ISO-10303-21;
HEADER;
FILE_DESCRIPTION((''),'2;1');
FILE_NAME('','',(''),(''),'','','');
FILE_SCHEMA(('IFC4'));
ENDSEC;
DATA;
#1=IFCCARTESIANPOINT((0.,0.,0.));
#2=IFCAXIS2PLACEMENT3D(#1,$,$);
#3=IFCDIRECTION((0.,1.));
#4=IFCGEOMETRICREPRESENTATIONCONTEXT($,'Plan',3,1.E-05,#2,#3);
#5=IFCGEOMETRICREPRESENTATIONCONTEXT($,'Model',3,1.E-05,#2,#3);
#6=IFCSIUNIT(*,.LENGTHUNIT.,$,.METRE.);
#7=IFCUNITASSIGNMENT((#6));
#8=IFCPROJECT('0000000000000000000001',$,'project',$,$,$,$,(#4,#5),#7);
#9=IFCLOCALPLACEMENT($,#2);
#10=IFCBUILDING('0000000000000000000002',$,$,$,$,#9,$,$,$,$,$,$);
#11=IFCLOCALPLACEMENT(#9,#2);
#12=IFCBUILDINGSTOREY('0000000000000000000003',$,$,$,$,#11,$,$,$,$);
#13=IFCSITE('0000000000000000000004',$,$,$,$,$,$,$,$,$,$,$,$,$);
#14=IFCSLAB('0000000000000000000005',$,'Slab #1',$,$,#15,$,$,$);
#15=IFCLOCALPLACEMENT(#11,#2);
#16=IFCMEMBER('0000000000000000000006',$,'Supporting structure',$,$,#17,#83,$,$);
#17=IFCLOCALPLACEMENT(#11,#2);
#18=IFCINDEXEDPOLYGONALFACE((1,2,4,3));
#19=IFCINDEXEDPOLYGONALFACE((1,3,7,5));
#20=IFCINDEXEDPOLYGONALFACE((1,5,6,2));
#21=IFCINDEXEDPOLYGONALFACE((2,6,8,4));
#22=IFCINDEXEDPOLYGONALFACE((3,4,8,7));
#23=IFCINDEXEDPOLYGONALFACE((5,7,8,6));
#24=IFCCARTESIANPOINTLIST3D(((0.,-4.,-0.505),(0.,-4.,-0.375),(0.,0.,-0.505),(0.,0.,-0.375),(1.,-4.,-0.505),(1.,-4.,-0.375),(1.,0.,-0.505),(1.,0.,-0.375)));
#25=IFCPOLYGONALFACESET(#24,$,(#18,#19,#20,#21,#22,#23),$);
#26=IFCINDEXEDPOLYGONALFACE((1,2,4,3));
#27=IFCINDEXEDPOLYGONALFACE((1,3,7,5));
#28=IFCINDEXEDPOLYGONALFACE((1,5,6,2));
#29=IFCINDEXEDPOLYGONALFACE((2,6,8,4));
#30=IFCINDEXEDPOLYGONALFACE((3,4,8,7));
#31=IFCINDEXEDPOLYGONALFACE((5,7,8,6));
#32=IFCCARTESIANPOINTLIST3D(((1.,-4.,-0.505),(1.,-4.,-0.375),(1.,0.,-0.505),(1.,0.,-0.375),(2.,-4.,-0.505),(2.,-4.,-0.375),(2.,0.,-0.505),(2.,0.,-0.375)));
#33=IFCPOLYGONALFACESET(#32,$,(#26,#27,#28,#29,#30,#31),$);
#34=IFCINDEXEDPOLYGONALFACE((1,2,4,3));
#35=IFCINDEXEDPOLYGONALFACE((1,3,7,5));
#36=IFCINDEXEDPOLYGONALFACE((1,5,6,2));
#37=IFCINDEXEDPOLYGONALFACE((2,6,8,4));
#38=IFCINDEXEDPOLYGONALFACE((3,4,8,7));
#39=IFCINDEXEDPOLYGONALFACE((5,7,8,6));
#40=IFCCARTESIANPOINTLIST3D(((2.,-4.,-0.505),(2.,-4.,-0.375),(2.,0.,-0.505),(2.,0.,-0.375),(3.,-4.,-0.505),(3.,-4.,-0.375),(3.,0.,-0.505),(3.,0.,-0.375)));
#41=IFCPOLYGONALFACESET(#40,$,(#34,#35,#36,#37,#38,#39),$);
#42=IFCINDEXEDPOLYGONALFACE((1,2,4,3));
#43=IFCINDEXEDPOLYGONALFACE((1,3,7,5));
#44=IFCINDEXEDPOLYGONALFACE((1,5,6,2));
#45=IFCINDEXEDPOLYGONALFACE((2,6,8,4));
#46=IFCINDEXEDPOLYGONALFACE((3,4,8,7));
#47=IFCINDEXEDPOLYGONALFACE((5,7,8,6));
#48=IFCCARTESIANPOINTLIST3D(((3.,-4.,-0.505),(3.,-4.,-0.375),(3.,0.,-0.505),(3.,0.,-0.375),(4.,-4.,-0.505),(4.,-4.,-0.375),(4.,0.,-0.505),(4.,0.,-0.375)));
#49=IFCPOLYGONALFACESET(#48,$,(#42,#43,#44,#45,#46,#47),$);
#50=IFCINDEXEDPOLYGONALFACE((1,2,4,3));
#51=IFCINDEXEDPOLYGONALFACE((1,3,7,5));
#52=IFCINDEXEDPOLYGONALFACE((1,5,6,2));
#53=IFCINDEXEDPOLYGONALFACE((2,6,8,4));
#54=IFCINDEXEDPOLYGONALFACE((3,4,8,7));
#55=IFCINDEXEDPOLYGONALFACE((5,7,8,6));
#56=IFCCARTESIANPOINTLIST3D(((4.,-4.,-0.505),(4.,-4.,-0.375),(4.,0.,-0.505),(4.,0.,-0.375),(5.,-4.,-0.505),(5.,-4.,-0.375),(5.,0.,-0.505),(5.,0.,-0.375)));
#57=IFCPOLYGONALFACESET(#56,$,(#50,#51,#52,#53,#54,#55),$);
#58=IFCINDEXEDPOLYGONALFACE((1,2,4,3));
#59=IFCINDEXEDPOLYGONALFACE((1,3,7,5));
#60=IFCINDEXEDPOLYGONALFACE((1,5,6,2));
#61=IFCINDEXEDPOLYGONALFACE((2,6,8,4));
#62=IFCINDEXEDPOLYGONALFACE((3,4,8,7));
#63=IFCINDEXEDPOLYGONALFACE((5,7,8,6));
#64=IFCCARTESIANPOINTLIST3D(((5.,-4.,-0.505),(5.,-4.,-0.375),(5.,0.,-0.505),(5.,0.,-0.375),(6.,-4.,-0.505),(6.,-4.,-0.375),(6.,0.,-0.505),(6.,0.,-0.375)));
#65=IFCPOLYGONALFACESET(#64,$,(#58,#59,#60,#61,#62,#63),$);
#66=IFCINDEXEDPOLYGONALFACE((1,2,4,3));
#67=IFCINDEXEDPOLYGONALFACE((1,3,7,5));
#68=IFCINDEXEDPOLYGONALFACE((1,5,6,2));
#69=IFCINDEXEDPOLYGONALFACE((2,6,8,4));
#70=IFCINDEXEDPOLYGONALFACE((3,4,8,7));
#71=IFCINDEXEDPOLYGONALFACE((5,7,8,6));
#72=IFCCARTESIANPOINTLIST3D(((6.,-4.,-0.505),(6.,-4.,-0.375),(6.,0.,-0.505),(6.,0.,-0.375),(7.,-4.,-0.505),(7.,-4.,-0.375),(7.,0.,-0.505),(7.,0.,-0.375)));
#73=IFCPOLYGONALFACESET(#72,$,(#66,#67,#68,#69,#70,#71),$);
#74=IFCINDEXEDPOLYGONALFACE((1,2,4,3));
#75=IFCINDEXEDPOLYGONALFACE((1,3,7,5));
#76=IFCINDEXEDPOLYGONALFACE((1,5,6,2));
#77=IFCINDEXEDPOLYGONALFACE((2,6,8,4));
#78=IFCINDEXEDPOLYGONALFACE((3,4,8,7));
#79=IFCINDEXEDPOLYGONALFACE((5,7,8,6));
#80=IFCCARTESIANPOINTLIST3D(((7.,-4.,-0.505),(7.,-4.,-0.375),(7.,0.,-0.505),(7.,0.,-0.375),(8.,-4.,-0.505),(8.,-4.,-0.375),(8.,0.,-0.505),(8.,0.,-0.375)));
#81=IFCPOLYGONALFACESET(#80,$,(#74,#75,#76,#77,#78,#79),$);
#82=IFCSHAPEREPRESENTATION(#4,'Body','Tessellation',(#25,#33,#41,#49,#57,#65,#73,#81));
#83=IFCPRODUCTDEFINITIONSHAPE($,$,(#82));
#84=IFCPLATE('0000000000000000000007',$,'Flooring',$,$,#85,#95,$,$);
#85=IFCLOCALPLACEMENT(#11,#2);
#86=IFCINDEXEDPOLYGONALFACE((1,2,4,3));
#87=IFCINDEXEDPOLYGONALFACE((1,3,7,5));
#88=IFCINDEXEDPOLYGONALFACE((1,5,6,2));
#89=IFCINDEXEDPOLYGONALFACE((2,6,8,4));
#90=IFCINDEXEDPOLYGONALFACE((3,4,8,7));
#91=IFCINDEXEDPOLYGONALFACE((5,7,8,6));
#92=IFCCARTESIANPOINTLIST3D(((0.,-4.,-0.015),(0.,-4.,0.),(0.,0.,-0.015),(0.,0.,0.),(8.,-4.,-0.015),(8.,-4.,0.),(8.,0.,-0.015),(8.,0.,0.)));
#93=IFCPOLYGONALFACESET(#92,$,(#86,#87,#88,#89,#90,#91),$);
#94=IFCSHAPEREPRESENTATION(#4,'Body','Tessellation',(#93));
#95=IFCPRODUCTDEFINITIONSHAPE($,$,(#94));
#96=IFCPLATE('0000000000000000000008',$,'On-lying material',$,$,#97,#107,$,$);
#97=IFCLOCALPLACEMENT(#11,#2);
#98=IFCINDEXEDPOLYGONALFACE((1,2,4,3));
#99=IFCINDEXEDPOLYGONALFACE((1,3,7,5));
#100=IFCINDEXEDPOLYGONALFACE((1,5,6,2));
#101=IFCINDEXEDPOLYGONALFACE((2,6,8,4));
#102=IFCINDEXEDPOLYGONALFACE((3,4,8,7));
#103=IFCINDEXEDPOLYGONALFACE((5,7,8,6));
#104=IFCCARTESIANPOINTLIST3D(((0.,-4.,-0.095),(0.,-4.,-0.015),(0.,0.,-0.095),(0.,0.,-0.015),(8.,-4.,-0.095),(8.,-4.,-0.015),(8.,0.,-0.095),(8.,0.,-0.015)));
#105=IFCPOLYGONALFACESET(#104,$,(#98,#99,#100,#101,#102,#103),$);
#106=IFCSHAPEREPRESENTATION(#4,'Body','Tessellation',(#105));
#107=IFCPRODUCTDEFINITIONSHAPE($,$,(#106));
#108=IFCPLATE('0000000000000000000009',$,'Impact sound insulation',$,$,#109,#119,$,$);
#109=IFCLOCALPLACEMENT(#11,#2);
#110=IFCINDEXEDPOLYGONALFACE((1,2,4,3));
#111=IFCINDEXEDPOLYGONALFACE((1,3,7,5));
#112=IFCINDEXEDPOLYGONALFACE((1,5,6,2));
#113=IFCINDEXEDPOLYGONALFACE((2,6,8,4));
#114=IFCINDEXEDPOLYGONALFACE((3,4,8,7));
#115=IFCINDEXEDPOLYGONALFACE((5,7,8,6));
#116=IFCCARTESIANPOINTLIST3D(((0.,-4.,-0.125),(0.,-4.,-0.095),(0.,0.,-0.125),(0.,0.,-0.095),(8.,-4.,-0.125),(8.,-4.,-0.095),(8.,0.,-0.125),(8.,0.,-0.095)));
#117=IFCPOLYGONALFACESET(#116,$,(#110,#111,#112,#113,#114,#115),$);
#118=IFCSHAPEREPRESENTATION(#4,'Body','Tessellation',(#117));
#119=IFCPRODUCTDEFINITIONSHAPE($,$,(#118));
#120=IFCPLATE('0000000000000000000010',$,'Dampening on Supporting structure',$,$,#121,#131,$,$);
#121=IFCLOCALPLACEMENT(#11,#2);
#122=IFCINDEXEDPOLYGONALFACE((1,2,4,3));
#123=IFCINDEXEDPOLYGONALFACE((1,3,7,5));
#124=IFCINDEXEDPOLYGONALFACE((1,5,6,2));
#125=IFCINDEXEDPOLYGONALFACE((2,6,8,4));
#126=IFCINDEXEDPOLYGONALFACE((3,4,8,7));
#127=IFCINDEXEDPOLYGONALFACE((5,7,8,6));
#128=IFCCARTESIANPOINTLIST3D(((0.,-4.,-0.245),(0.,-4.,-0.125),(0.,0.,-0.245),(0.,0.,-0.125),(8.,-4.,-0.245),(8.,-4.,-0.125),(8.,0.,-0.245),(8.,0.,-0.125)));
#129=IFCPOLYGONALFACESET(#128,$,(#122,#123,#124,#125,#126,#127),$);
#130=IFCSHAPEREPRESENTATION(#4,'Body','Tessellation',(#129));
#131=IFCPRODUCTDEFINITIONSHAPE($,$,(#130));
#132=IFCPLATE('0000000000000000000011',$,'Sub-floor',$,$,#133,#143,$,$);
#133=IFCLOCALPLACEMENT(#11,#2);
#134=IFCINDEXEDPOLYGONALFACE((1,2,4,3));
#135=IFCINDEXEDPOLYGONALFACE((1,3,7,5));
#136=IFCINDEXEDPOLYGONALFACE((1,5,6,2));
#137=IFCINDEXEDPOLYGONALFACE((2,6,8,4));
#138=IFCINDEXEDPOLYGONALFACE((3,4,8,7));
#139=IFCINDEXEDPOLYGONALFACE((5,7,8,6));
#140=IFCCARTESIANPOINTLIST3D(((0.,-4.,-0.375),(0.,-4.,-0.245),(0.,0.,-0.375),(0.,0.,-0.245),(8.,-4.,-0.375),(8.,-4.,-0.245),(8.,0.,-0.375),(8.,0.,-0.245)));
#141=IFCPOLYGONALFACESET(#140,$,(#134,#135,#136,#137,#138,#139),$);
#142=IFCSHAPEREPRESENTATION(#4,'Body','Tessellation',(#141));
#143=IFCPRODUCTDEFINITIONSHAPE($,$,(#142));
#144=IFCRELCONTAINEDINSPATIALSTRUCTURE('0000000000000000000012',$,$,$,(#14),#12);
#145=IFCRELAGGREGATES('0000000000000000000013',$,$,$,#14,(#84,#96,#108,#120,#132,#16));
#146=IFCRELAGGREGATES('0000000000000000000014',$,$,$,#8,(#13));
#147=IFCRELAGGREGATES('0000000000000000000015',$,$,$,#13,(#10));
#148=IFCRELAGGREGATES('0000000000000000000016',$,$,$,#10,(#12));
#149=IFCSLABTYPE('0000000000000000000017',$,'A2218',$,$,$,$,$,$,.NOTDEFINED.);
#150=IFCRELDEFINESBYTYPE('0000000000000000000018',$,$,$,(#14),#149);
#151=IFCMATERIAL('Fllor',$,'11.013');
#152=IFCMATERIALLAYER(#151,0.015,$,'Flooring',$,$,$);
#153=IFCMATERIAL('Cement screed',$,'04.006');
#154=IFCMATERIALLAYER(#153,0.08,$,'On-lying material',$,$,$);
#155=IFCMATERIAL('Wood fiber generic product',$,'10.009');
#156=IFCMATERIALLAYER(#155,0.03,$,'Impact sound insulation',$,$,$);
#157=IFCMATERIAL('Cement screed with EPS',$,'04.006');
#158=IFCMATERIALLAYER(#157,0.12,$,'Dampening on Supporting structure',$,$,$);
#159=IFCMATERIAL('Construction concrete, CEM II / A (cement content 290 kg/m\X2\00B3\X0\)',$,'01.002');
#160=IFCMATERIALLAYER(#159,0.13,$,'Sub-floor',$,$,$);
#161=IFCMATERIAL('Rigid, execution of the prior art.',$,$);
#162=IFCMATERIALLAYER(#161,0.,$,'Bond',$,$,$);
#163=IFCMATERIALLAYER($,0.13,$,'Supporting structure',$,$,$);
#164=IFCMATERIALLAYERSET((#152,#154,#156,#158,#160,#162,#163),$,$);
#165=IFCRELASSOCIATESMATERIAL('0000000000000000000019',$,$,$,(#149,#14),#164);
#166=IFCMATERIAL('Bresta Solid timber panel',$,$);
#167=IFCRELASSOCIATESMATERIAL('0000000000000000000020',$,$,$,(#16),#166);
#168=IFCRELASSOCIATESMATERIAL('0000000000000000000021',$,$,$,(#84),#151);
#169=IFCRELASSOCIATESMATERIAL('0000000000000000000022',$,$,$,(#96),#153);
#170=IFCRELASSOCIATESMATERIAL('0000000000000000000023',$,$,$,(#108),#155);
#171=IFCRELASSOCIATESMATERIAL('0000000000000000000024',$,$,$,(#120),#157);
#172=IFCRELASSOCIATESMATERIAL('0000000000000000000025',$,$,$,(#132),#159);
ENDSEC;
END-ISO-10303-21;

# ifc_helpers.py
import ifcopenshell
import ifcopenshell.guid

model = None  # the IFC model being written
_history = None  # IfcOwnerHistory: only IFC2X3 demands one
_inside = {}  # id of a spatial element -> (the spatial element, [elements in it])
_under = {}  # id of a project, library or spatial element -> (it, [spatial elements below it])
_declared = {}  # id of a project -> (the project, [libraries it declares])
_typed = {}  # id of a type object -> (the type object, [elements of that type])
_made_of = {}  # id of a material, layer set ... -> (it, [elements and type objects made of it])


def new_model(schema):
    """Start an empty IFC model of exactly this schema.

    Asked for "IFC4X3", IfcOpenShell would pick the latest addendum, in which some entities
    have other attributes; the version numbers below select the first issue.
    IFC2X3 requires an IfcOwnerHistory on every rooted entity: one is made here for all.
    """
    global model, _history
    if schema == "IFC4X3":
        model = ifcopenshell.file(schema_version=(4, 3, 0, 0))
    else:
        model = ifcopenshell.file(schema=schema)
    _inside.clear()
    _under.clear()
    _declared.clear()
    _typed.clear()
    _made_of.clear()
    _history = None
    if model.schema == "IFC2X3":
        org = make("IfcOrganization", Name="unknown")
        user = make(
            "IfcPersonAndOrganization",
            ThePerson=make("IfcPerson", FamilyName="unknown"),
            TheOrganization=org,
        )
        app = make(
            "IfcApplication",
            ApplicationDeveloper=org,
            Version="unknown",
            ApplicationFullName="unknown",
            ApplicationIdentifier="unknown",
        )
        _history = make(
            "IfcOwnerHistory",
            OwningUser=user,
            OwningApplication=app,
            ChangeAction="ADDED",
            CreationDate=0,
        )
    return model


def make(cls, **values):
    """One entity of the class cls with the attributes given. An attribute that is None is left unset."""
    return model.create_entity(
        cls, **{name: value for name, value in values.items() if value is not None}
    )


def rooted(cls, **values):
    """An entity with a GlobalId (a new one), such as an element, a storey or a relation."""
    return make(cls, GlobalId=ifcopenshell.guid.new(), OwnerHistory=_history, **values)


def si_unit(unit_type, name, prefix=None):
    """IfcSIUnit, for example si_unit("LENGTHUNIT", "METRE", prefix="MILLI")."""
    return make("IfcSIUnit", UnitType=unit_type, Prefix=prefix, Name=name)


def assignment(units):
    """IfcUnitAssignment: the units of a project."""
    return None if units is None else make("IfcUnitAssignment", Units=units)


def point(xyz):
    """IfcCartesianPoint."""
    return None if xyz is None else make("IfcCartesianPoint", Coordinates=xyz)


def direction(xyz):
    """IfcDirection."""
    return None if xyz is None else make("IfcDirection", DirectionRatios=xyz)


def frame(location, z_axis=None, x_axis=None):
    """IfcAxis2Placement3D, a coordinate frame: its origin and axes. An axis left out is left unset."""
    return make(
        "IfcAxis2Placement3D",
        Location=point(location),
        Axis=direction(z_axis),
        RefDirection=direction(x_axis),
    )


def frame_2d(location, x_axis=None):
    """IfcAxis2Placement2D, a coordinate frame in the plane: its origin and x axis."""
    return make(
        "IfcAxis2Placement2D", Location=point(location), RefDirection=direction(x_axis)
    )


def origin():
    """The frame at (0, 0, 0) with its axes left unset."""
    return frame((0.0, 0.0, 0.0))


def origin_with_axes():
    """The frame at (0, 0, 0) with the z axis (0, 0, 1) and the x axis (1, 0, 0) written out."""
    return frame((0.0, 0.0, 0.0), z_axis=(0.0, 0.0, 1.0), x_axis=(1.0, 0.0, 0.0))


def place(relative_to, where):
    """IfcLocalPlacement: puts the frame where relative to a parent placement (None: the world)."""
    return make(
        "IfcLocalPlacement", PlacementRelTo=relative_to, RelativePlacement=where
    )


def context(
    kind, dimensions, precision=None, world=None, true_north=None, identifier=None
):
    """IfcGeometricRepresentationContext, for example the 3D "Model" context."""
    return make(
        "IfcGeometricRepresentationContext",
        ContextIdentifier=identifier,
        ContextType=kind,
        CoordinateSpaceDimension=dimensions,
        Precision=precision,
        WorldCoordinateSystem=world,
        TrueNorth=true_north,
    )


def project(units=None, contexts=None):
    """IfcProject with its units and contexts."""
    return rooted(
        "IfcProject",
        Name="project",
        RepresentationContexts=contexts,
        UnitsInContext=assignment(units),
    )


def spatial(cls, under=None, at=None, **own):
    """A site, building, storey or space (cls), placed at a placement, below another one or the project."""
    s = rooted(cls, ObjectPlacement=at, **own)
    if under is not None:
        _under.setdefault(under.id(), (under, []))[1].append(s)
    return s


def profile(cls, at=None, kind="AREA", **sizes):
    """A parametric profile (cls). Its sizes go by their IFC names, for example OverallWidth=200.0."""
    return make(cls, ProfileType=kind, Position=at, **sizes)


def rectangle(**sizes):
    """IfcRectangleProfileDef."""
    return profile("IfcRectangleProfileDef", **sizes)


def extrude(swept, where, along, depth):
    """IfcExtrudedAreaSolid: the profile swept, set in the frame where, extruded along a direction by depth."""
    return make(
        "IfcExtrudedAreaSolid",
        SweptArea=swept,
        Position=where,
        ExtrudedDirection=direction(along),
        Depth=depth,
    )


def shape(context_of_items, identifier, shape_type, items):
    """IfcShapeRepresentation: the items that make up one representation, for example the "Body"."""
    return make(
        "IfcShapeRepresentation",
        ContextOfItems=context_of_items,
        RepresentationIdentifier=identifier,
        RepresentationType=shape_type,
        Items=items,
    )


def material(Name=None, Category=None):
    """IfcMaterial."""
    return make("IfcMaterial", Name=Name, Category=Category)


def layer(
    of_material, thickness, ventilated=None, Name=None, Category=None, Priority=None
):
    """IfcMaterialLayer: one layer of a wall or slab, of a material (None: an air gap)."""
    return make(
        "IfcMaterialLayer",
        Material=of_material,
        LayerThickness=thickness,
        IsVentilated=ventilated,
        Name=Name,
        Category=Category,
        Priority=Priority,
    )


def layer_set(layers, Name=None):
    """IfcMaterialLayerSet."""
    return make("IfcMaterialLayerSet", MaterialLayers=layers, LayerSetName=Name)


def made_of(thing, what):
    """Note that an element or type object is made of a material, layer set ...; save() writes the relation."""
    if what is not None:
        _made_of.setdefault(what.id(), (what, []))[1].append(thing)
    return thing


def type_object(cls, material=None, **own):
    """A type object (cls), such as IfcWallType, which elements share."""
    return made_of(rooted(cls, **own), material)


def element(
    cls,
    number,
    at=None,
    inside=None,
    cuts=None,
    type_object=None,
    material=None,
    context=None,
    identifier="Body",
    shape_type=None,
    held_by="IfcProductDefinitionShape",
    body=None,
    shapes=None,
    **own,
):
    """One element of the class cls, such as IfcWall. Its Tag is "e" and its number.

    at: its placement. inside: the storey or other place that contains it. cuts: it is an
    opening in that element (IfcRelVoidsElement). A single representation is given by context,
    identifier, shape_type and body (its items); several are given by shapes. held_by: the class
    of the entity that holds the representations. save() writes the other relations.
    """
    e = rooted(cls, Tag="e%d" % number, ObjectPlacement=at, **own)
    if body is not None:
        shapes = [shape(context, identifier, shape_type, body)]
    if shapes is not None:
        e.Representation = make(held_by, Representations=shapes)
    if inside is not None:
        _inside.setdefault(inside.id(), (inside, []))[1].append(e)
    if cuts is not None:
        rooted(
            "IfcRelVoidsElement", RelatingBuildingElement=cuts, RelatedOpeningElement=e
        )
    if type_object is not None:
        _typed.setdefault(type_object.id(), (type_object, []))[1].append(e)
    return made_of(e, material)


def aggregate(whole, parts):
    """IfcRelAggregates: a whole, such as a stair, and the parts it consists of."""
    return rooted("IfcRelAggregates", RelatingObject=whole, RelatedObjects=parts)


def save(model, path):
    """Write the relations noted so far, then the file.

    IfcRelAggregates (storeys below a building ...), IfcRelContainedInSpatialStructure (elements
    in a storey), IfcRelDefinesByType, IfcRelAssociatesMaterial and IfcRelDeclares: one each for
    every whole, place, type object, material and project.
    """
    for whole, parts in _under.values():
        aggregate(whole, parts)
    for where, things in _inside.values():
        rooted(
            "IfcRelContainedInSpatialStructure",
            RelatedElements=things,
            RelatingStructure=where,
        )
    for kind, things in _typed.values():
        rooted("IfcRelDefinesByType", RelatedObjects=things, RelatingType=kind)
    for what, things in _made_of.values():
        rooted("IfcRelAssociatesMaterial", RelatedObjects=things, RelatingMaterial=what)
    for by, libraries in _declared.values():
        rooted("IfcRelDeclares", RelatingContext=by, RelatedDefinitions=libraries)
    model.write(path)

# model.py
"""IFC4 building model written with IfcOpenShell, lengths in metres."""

from ifc_helpers import new_model, si_unit, direction, frame, frame_2d, origin, origin_with_axes, place, context, project, spatial, rectangle, extrude, material, layer, layer_set, type_object, element, aggregate, save


model = new_model("IFC4")

# Units and contexts
plan_context = context("Plan", 3, precision=1e-05, world=origin(), true_north=direction((0.0, 1.0)))
model_context = context("Model", 3, precision=1e-05, world=origin(), true_north=direction((0.0, 1.0)))
ifc_project = project(units=[si_unit("LENGTHUNIT", "METRE")], contexts=[plan_context, model_context])

# Site, building, storey
site = spatial("IfcSite", under=ifc_project)
building_placement = place(None, origin())
building = spatial("IfcBuilding", under=site, at=building_placement)
storey_placement = place(building_placement, origin())
storey = spatial("IfcBuildingStorey", under=building, at=storey_placement)

# Slab, member, plates
ifc_material_1 = material(Name="Fllor", Category="11.013")
ifc_layer_1 = layer(ifc_material_1, 0.015, Name="Flooring")
ifc_material_2 = material(Name="Cement screed", Category="04.006")
ifc_layer_2 = layer(ifc_material_2, 0.08, Name="On-lying material")
ifc_material_3 = material(Name="Wood fiber generic product", Category="10.009")
ifc_layer_3 = layer(ifc_material_3, 0.03, Name="Impact sound insulation")
ifc_material_4 = material(Name="Cement screed with EPS", Category="04.006")
ifc_layer_4 = layer(ifc_material_4, 0.12, Name="Dampening on Supporting structure")
ifc_material_5 = material(Name="Construction concrete, CEM II / A (cement content 290 kg/m³)", Category="01.002")
ifc_layer_5 = layer(ifc_material_5, 0.13, Name="Sub-floor")
ifc_material_6 = material(Name="Rigid, execution of the prior art.")
ifc_layer_6 = layer(ifc_material_6, 0.0, Name="Bond")
ifc_layer_7 = layer(None, 0.13, Name="Supporting structure")
ifc_layer_set = layer_set([ifc_layer_1, ifc_layer_2, ifc_layer_3, ifc_layer_4, ifc_layer_5, ifc_layer_6, ifc_layer_7])
slab_type = type_object("IfcSlabType", Name="A2218", PredefinedType="NOTDEFINED", material=ifc_layer_set)
slab_placement = place(None, frame((0.0, 0.0, 0.0), z_axis=(0.0, 0.0, -1.0), x_axis=(1.0, 0.0, 0.0)))
slab = element("IfcSlab", 1, at=slab_placement, inside=storey, type_object=slab_type, material=ifc_layer_set, Name="Slab #1")
ifc_material_7 = material(Name="Bresta Solid timber panel")
member_placement = place(slab_placement, origin())
member = element("IfcMember", 2, at=member_placement, material=ifc_material_7, Name="Supporting structure", context=plan_context, shape_type="SweptSolid", body=[
    extrude(rectangle(XDim=1.0, YDim=0.13, at=frame_2d((0.5, 0.065), x_axis=(1.0, 0.0))), frame((0.0, 4.0, 0.375), z_axis=(0.0, -1.0, 0.0), x_axis=(1.0, 0.0, 0.0)), (0.0, 0.0, 1.0), 4.0),
    extrude(rectangle(XDim=1.0, YDim=0.13, at=frame_2d((0.5, 0.065), x_axis=(1.0, 0.0))), frame((1.0, 4.0, 0.375), z_axis=(0.0, -1.0, 0.0), x_axis=(1.0, 0.0, 0.0)), (0.0, 0.0, 1.0), 4.0),
    extrude(rectangle(XDim=1.0, YDim=0.13, at=frame_2d((0.5, 0.065), x_axis=(1.0, 0.0))), frame((2.0, 4.0, 0.375), z_axis=(0.0, -1.0, 0.0), x_axis=(1.0, 0.0, 0.0)), (0.0, 0.0, 1.0), 4.0),
    extrude(rectangle(XDim=1.0, YDim=0.13, at=frame_2d((0.5, 0.065), x_axis=(1.0, 0.0))), frame((3.0, 4.0, 0.375), z_axis=(0.0, -1.0, 0.0), x_axis=(1.0, 0.0, 0.0)), (0.0, 0.0, 1.0), 4.0),
    extrude(rectangle(XDim=1.0, YDim=0.13, at=frame_2d((0.5, 0.065), x_axis=(1.0, 0.0))), frame((4.0, 4.0, 0.375), z_axis=(0.0, -1.0, 0.0), x_axis=(1.0, 0.0, 0.0)), (0.0, 0.0, 1.0), 4.0),
    extrude(rectangle(XDim=1.0, YDim=0.13, at=frame_2d((0.5, 0.065), x_axis=(1.0, 0.0))), frame((5.0, 4.0, 0.375), z_axis=(0.0, -1.0, 0.0), x_axis=(1.0, 0.0, 0.0)), (0.0, 0.0, 1.0), 4.0),
    extrude(rectangle(XDim=1.0, YDim=0.13, at=frame_2d((0.5, 0.065), x_axis=(1.0, 0.0))), frame((6.0, 4.0, 0.375), z_axis=(0.0, -1.0, 0.0), x_axis=(1.0, 0.0, 0.0)), (0.0, 0.0, 1.0), 4.0),
    extrude(rectangle(XDim=1.0, YDim=0.13, at=frame_2d((0.5, 0.065), x_axis=(1.0, 0.0))), frame((7.0, 4.0, 0.375), z_axis=(0.0, -1.0, 0.0), x_axis=(1.0, 0.0, 0.0)), (0.0, 0.0, 1.0), 4.0),
])
plate_1_placement = place(slab_placement, origin())
plate_1 = element("IfcPlate", 3, at=plate_1_placement, material=ifc_material_1, Name="Flooring", context=plan_context, shape_type="SweptSolid", body=[
    extrude(rectangle(XDim=8.0, YDim=4.0, at=frame_2d((4.0, 2.0), x_axis=(1.0, 0.0))), origin_with_axes(), (0.0, 0.0, 1.0), 0.015),
])
plate_2_placement = place(slab_placement, origin())
plate_2 = element("IfcPlate", 4, at=plate_2_placement, material=ifc_material_2, Name="On-lying material", context=plan_context, shape_type="SweptSolid", body=[
    extrude(rectangle(XDim=8.0, YDim=4.0, at=frame_2d((4.0, 2.0), x_axis=(1.0, 0.0))), frame((0.0, 0.0, 0.015), z_axis=(0.0, 0.0, 1.0), x_axis=(1.0, 0.0, 0.0)), (0.0, 0.0, 1.0), 0.08),
])
plate_3_placement = place(slab_placement, origin())
plate_3 = element("IfcPlate", 5, at=plate_3_placement, material=ifc_material_3, Name="Impact sound insulation", context=plan_context, shape_type="SweptSolid", body=[
    extrude(rectangle(XDim=8.0, YDim=4.0, at=frame_2d((4.0, 2.0), x_axis=(1.0, 0.0))), frame((0.0, 0.0, 0.095), z_axis=(0.0, 0.0, 1.0), x_axis=(1.0, 0.0, 0.0)), (0.0, 0.0, 1.0), 0.03),
])
plate_4_placement = place(slab_placement, origin())
plate_4 = element("IfcPlate", 6, at=plate_4_placement, material=ifc_material_4, Name="Dampening on Supporting structure", context=plan_context, shape_type="SweptSolid", body=[
    extrude(rectangle(XDim=8.0, YDim=4.0, at=frame_2d((4.0, 2.0), x_axis=(1.0, 0.0))), frame((0.0, 0.0, 0.125), z_axis=(0.0, 0.0, 1.0), x_axis=(1.0, 0.0, 0.0)), (0.0, 0.0, 1.0), 0.12),
])
plate_5_placement = place(slab_placement, origin())
plate_5 = element("IfcPlate", 7, at=plate_5_placement, material=ifc_material_5, Name="Sub-floor", context=plan_context, shape_type="SweptSolid", body=[
    extrude(rectangle(XDim=8.0, YDim=4.0, at=frame_2d((4.0, 2.0), x_axis=(1.0, 0.0))), frame((0.0, 0.0, 0.245), z_axis=(0.0, 0.0, 1.0), x_axis=(1.0, 0.0, 0.0)), (0.0, 0.0, 1.0), 0.13),
])
aggregate(slab, [plate_1, plate_2, plate_3, plate_4, plate_5, member])

save(model, "model.ifc")
